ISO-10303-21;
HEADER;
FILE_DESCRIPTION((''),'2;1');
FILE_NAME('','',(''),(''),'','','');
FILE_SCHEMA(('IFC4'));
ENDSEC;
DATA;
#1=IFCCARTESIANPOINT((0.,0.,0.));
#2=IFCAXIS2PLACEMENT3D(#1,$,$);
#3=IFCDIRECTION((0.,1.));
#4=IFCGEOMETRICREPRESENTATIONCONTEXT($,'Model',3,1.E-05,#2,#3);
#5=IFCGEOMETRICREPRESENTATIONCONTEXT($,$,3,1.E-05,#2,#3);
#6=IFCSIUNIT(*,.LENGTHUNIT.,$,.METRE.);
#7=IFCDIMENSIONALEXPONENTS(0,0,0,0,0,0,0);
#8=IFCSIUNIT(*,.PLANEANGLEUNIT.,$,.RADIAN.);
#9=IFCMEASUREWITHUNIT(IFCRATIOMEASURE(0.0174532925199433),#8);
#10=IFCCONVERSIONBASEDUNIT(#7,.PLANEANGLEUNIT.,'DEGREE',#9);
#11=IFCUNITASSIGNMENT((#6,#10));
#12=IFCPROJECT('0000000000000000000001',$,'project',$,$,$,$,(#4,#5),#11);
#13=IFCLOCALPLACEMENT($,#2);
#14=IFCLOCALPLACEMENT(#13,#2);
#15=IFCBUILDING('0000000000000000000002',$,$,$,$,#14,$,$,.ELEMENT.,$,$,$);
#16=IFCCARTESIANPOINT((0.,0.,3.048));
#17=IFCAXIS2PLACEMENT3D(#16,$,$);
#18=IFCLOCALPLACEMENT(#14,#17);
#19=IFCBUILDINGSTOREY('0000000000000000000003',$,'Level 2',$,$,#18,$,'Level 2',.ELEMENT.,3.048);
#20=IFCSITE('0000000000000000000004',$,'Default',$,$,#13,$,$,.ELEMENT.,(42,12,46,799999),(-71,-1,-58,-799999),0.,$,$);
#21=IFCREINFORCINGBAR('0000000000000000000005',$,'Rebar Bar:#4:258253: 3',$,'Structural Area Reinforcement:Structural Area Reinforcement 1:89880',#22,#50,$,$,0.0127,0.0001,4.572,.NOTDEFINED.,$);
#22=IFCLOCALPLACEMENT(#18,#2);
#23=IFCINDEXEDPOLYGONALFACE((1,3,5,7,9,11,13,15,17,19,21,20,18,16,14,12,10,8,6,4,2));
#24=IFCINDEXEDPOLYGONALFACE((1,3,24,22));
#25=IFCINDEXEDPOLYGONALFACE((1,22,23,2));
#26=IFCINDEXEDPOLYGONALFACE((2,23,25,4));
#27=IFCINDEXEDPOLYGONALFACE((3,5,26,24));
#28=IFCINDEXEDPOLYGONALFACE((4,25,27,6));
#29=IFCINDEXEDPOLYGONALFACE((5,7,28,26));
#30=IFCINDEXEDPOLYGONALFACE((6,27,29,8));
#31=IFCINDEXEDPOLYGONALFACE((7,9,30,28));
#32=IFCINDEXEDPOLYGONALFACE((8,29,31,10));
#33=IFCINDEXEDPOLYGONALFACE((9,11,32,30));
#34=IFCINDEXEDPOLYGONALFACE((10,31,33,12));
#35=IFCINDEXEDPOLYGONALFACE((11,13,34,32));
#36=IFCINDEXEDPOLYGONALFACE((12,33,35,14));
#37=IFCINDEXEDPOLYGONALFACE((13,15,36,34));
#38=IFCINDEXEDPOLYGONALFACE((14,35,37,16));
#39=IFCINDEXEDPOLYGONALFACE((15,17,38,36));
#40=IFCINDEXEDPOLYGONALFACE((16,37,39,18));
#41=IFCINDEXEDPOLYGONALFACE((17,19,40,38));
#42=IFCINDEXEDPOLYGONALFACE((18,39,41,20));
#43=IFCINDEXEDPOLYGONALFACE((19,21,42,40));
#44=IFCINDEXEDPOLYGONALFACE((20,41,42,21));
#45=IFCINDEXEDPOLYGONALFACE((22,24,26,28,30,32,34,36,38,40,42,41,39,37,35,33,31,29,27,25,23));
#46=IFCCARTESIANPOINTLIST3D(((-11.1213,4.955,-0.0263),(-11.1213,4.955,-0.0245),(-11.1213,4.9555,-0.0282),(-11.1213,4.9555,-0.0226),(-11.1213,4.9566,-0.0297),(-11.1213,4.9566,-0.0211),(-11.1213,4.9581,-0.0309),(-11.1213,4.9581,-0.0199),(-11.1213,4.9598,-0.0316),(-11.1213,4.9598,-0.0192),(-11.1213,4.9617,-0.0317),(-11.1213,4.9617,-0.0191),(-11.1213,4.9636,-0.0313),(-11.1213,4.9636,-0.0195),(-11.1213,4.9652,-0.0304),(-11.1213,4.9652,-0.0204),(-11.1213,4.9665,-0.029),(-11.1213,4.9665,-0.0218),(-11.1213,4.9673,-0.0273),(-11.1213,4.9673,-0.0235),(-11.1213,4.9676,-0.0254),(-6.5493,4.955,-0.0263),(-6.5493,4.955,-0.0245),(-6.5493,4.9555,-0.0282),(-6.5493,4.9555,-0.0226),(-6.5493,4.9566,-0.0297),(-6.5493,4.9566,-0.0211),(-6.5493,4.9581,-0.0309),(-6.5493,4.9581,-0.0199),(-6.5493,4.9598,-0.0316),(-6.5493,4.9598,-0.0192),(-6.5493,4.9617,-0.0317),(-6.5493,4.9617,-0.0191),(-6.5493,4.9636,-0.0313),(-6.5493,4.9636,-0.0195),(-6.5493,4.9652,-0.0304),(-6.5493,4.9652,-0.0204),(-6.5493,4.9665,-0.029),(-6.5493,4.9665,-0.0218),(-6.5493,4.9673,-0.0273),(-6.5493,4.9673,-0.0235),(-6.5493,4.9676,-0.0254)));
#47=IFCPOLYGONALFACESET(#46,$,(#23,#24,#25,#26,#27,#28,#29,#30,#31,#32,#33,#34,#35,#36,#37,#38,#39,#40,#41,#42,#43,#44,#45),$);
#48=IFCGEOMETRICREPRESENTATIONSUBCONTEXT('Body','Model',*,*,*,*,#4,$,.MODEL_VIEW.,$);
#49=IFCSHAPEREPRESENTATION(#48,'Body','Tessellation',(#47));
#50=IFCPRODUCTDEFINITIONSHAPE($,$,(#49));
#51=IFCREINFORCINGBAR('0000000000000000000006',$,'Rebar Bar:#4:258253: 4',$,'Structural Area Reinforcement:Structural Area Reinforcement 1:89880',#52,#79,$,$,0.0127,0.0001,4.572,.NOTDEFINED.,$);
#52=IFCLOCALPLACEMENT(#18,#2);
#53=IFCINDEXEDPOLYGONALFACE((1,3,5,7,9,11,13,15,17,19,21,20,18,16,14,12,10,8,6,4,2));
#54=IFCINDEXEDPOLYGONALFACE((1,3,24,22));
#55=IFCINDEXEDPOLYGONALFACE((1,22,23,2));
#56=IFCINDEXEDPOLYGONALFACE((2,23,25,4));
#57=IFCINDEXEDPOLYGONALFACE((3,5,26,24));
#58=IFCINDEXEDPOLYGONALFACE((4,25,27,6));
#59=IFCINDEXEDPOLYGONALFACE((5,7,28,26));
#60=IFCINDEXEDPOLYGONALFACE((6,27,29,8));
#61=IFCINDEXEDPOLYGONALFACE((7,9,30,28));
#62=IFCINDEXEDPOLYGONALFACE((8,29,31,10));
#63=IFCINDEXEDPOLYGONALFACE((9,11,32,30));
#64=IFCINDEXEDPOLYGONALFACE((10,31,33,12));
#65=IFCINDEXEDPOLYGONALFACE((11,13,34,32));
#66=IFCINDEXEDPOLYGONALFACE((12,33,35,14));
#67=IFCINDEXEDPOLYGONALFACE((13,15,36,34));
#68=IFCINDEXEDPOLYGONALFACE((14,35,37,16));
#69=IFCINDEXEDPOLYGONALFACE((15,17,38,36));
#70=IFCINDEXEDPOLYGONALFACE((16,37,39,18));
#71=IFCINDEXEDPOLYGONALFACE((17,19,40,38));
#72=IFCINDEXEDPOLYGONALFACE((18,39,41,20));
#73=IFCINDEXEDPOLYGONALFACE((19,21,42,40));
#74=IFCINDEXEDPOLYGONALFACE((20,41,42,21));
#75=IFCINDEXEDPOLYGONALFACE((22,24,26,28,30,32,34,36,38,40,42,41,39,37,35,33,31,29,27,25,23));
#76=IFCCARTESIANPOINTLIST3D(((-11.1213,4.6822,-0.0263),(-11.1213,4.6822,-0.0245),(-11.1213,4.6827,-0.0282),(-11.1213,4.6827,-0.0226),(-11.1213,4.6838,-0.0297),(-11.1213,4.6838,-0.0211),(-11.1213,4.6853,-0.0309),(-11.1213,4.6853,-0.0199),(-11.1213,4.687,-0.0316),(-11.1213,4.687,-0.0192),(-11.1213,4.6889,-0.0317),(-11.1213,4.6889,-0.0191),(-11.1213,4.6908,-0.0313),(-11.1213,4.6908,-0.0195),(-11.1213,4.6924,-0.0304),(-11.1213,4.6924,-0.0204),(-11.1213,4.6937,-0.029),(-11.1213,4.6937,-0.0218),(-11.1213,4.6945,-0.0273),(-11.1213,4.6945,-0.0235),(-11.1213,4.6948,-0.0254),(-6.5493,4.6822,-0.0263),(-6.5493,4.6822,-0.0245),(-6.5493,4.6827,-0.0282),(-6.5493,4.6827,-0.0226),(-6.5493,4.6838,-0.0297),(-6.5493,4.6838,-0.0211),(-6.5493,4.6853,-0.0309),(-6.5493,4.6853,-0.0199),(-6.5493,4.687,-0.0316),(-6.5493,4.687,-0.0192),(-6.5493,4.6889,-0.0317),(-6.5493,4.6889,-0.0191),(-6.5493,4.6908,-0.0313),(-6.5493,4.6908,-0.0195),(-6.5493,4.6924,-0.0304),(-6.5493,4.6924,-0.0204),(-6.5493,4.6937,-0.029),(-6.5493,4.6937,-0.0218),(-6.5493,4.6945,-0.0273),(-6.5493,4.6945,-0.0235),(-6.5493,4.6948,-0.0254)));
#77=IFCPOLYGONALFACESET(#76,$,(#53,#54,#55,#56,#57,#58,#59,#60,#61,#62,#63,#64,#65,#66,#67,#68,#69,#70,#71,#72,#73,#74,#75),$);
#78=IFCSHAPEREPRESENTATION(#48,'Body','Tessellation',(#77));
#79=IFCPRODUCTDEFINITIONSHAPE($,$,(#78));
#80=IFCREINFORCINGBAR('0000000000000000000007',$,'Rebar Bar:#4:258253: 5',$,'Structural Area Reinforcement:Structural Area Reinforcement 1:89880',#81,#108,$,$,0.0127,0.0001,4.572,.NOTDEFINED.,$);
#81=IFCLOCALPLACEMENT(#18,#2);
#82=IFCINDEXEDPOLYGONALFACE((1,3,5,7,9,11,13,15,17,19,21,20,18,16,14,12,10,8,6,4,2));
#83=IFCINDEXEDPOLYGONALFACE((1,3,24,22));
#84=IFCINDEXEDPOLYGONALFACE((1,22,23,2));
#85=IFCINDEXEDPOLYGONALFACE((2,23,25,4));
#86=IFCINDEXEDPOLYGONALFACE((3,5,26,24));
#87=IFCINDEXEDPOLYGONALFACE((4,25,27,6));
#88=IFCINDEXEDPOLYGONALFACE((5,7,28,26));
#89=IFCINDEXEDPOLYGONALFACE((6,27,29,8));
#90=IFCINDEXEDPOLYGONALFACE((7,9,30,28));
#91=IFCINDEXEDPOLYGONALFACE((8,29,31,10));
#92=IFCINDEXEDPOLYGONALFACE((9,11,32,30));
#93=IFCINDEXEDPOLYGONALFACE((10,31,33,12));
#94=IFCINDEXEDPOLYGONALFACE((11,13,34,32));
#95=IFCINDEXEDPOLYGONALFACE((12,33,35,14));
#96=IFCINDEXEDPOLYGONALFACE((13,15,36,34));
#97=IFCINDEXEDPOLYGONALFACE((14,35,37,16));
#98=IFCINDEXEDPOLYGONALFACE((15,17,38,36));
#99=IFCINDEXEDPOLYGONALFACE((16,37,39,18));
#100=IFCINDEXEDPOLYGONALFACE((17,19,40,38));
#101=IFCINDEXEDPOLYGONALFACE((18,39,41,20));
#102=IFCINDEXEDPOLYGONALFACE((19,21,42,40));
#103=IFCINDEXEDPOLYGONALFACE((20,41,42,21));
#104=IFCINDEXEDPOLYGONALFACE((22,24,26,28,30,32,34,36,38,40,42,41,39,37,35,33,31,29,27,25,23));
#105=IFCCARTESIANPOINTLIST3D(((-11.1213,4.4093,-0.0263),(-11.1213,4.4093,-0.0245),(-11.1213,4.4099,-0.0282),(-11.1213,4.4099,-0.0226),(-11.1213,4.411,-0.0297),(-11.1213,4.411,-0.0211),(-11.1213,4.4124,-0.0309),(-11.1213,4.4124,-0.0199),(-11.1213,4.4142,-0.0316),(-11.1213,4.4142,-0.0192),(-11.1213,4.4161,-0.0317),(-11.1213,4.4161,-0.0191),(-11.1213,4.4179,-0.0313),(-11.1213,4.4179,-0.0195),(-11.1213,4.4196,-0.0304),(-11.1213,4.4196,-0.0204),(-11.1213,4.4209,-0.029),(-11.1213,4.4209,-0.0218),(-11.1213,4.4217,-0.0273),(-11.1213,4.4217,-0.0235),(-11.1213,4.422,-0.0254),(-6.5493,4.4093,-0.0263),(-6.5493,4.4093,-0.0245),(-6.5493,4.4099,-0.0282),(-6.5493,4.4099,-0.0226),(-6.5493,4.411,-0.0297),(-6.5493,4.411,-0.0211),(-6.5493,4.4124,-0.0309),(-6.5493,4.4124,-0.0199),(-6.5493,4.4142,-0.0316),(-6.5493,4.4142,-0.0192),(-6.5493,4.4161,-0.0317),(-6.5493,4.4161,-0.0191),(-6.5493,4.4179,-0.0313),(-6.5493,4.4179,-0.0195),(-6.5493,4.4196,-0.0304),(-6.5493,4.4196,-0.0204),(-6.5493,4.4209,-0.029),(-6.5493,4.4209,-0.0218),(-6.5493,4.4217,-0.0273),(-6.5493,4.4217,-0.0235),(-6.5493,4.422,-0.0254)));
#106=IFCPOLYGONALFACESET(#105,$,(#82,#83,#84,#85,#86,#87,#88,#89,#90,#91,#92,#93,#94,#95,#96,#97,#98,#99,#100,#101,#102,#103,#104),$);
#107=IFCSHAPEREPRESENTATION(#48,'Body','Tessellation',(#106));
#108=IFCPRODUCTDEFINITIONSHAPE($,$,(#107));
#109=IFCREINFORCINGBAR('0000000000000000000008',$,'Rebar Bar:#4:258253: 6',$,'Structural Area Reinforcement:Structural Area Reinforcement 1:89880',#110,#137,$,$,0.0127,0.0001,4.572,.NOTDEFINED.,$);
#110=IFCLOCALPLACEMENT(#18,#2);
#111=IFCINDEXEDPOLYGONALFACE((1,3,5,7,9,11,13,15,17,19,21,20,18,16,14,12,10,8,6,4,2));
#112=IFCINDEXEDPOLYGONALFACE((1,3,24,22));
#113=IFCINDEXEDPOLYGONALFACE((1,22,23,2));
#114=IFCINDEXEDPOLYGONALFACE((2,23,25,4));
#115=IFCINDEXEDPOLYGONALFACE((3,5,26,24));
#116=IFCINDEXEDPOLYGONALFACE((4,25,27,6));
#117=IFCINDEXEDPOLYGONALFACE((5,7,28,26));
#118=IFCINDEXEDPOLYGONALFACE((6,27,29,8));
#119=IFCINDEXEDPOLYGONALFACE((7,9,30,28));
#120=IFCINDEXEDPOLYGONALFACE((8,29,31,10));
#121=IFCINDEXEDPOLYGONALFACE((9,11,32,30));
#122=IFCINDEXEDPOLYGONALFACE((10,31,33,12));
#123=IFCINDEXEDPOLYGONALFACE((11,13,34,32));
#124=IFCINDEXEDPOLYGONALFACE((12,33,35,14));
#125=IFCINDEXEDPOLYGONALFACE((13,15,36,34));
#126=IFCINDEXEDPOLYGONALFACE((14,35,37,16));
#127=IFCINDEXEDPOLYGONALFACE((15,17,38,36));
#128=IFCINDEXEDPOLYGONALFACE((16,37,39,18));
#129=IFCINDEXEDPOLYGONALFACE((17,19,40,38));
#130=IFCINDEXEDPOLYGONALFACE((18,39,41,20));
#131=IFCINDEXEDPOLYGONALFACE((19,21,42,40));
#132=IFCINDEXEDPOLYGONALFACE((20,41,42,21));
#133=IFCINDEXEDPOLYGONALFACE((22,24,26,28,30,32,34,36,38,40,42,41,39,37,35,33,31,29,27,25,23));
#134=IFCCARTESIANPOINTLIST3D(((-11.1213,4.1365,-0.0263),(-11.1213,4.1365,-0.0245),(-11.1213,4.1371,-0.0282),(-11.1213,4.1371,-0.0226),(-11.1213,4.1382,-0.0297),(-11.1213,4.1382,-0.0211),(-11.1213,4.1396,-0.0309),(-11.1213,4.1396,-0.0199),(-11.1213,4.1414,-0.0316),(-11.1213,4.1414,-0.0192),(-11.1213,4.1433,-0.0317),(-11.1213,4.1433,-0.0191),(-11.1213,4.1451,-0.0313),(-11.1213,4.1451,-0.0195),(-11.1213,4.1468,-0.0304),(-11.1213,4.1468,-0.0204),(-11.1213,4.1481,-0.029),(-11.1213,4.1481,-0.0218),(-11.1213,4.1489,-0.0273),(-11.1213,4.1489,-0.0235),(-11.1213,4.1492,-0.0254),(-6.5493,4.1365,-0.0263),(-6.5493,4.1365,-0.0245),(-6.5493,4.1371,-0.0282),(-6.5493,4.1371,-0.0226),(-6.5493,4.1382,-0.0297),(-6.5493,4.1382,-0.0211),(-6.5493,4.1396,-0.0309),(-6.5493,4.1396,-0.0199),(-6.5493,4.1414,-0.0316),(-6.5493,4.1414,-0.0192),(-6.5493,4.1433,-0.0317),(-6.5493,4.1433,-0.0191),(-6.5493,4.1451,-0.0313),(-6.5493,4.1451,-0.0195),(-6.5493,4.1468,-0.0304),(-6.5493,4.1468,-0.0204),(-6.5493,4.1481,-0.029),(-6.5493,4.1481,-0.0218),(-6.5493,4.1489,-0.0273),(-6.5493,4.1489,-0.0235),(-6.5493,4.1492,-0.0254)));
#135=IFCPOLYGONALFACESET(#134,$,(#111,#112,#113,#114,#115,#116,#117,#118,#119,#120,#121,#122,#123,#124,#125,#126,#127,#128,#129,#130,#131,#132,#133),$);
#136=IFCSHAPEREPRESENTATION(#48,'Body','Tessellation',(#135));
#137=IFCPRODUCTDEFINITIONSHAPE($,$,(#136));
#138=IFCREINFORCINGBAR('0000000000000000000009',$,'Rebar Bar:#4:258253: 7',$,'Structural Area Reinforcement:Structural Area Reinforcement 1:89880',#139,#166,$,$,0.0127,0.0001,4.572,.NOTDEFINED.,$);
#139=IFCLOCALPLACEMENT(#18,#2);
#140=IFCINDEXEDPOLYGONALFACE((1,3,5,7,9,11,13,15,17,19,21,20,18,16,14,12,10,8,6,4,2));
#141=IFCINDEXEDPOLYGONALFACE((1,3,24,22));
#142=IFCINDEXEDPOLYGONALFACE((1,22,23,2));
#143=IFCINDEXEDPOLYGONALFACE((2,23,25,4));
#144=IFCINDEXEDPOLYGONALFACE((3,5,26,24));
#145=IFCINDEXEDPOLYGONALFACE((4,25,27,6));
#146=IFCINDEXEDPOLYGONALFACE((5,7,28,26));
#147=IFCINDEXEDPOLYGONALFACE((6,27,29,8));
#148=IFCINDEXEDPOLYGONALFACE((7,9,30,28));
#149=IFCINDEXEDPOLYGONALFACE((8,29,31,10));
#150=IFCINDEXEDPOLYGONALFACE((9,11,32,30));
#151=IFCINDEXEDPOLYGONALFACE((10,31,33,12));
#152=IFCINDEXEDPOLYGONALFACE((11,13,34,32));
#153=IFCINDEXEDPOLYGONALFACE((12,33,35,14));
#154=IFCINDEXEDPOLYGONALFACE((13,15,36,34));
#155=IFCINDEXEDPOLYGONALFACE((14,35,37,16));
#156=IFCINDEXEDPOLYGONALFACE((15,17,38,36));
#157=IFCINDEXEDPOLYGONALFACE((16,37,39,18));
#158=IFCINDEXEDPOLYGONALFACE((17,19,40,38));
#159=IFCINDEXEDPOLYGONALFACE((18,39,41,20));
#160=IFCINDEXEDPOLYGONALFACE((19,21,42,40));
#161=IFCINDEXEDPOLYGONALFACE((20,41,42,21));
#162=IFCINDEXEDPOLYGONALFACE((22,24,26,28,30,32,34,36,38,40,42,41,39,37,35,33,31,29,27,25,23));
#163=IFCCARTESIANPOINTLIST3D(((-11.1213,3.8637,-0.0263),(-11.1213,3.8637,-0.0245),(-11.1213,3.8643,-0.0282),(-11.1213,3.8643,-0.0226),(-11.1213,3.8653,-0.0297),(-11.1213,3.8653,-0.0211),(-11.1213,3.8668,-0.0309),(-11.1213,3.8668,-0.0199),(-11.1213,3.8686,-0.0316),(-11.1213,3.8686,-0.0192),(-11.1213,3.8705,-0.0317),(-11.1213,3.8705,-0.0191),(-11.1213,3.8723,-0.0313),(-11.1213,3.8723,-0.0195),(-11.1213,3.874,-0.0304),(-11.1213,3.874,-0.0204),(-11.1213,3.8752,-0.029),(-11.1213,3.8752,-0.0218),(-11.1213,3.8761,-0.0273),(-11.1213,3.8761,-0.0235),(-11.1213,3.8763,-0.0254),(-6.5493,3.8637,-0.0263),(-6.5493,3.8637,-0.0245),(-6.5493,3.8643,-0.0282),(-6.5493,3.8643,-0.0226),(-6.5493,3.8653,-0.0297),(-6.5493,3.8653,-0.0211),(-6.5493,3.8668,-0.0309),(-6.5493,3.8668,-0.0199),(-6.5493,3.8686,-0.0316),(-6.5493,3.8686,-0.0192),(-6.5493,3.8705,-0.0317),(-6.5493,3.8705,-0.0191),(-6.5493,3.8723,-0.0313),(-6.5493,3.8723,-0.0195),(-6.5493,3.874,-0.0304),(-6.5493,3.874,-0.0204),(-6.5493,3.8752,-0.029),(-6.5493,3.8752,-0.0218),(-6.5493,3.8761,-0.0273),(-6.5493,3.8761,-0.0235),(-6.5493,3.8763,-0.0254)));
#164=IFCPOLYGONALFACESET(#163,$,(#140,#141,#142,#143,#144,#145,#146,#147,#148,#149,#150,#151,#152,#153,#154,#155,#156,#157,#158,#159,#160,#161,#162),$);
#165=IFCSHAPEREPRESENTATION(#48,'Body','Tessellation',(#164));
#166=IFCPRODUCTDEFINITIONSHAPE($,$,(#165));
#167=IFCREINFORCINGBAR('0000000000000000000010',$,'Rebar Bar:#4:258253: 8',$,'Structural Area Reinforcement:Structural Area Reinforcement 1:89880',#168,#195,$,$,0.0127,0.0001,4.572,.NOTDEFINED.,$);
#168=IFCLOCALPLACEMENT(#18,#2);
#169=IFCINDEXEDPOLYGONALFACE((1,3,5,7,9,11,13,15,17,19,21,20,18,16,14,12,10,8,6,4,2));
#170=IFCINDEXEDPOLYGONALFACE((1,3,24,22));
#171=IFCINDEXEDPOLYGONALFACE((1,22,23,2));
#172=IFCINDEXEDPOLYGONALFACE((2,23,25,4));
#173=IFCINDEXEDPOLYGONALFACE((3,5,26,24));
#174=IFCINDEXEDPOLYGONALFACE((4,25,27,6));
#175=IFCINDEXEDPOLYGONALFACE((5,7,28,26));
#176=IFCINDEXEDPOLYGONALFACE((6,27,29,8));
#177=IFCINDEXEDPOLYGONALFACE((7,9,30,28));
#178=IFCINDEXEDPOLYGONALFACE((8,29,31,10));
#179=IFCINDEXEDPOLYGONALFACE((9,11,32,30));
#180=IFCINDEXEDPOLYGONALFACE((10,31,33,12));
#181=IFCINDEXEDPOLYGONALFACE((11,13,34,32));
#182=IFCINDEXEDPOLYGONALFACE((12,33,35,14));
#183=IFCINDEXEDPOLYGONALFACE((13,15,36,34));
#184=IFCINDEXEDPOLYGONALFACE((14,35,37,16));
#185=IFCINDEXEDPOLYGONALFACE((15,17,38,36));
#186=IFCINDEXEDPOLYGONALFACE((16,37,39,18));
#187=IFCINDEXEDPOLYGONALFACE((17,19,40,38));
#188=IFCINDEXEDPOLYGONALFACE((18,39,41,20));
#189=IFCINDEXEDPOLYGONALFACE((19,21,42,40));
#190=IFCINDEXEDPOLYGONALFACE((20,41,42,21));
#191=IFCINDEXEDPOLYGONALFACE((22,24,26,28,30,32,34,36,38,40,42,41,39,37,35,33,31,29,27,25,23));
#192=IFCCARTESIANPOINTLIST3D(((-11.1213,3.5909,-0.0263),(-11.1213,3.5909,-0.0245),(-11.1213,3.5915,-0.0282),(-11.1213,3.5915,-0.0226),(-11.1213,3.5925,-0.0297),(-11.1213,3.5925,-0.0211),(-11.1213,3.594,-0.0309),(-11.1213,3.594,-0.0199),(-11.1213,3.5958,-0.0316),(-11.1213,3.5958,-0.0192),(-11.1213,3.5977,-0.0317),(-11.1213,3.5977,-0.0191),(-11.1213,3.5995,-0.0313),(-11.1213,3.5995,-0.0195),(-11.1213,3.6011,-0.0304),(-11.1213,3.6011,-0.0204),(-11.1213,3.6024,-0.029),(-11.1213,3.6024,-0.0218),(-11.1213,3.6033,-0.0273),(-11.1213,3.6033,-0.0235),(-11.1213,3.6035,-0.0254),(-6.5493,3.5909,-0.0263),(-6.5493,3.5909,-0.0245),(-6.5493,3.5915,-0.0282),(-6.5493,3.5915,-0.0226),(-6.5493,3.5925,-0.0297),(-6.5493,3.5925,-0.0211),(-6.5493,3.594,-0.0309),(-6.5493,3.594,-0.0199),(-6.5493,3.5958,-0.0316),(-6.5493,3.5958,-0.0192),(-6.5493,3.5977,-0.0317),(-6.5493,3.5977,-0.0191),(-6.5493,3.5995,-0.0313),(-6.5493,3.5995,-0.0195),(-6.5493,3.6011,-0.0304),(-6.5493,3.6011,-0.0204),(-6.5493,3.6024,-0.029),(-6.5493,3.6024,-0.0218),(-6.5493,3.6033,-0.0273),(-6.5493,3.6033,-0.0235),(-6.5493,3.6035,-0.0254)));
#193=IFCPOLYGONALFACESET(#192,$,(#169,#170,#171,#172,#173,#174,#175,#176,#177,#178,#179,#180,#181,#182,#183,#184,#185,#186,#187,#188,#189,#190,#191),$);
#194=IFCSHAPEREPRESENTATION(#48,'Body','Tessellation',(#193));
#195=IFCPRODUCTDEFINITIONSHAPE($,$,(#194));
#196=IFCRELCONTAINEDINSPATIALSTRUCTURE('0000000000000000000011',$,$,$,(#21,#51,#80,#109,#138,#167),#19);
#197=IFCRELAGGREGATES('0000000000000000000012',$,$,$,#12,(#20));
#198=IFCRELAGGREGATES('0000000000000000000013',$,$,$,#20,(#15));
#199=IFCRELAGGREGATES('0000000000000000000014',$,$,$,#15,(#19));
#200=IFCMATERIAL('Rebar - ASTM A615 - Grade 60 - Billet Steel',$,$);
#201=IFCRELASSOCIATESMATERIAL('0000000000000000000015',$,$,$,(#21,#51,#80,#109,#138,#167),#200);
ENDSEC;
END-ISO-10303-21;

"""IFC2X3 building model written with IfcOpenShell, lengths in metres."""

from ifc_helpers import new_model, entity, si_unit, converted_unit, direction, frame, origin, place, context, subcontext, project, spatial, material, element, save


model = new_model("IFC2X3")

# Units and contexts
model_context = context("Model", 3, precision=1e-05, world=origin(), true_north=direction((0.0, 1.0)))
context_of_model = context(None, 3, precision=1e-05, world=origin(), true_north=direction((0.0, 1.0)))
body_context = subcontext(model_context, "Body", "Model", "MODEL_VIEW")
ifc_project = project(units=[si_unit("LENGTHUNIT", "METRE"), converted_unit("PLANEANGLEUNIT", "DEGREE", entity("IfcRatioMeasure", 0.0174532925199433), si_unit("PLANEANGLEUNIT", "RADIAN"), dimensions=[0, 0, 0, 0, 0, 0, 0])], contexts=[model_context, context_of_model])

# Site, building, storey
site_placement = place(None, origin())
site = spatial("IfcSite", under=ifc_project, at=site_placement, Name="Default", CompositionType="ELEMENT", RefLatitude=(42, 12, 46, 799999), RefLongitude=(-71, -1, -58, -799999), RefElevation=0.0)
building_placement = place(site_placement, origin())
building = spatial("IfcBuilding", under=site, at=building_placement, CompositionType="ELEMENT")
storey_placement = place(building_placement, frame((0.0, 0.0, 3.048)))
storey = spatial("IfcBuildingStorey", under=building, at=storey_placement, Name="Level 2", LongName="Level 2", CompositionType="ELEMENT", Elevation=3.048)

# Reinforcing bars
ifc_material_1 = material(Name="Rebar - ASTM A615 - Grade 60 - Billet Steel")
reinforcing_bar_1_placement = place(storey_placement, origin())
element("IfcReinforcingBar", 1, at=reinforcing_bar_1_placement, inside=storey, material=ifc_material_1, Name="Rebar Bar:#4:258253: 3", ObjectType="Structural Area Reinforcement:Structural Area Reinforcement 1:89880", BarLength=4.572, BarRole="NOTDEFINED", CrossSectionArea=0.0001, NominalDiameter=0.0127, context=body_context, shape_type="AdvancedSweptSolid", body=[
    entity("IfcSweptDiskSolid", entity("IfcCompositeCurve", [entity("IfcCompositeCurveSegment", "CONTINUOUS", True, entity("IfcPolyline", [entity("IfcCartesianPoint", [-11.1213, 4.9612, -0.0254]), entity("IfcCartesianPoint", [-6.5493, 4.9612, -0.0254])]))], False), 0.0063, None, 0.0, 1.0),
])
reinforcing_bar_2_placement = place(storey_placement, origin())
element("IfcReinforcingBar", 2, at=reinforcing_bar_2_placement, inside=storey, material=ifc_material_1, Name="Rebar Bar:#4:258253: 4", ObjectType="Structural Area Reinforcement:Structural Area Reinforcement 1:89880", BarLength=4.572, BarRole="NOTDEFINED", CrossSectionArea=0.0001, NominalDiameter=0.0127, context=body_context, shape_type="AdvancedSweptSolid", body=[
    entity("IfcSweptDiskSolid", entity("IfcCompositeCurve", [entity("IfcCompositeCurveSegment", "CONTINUOUS", True, entity("IfcPolyline", [entity("IfcCartesianPoint", [-11.1213, 4.6884, -0.0254]), entity("IfcCartesianPoint", [-6.5493, 4.6884, -0.0254])]))], False), 0.0063, None, 0.0, 1.0),
])
reinforcing_bar_3_placement = place(storey_placement, origin())
element("IfcReinforcingBar", 3, at=reinforcing_bar_3_placement, inside=storey, material=ifc_material_1, Name="Rebar Bar:#4:258253: 5", ObjectType="Structural Area Reinforcement:Structural Area Reinforcement 1:89880", BarLength=4.572, BarRole="NOTDEFINED", CrossSectionArea=0.0001, NominalDiameter=0.0127, context=body_context, shape_type="AdvancedSweptSolid", body=[
    entity("IfcSweptDiskSolid", entity("IfcCompositeCurve", [entity("IfcCompositeCurveSegment", "CONTINUOUS", True, entity("IfcPolyline", [entity("IfcCartesianPoint", [-11.1213, 4.4156, -0.0254]), entity("IfcCartesianPoint", [-6.5493, 4.4156, -0.0254])]))], False), 0.0063, None, 0.0, 1.0),
])
reinforcing_bar_4_placement = place(storey_placement, origin())
element("IfcReinforcingBar", 4, at=reinforcing_bar_4_placement, inside=storey, material=ifc_material_1, Name="Rebar Bar:#4:258253: 6", ObjectType="Structural Area Reinforcement:Structural Area Reinforcement 1:89880", BarLength=4.572, BarRole="NOTDEFINED", CrossSectionArea=0.0001, NominalDiameter=0.0127, context=body_context, shape_type="AdvancedSweptSolid", body=[
    entity("IfcSweptDiskSolid", entity("IfcCompositeCurve", [entity("IfcCompositeCurveSegment", "CONTINUOUS", True, entity("IfcPolyline", [entity("IfcCartesianPoint", [-11.1213, 4.1428, -0.0254]), entity("IfcCartesianPoint", [-6.5493, 4.1428, -0.0254])]))], False), 0.0063, None, 0.0, 1.0),
])
reinforcing_bar_5_placement = place(storey_placement, origin())
element("IfcReinforcingBar", 5, at=reinforcing_bar_5_placement, inside=storey, material=ifc_material_1, Name="Rebar Bar:#4:258253: 7", ObjectType="Structural Area Reinforcement:Structural Area Reinforcement 1:89880", BarLength=4.572, BarRole="NOTDEFINED", CrossSectionArea=0.0001, NominalDiameter=0.0127, context=body_context, shape_type="AdvancedSweptSolid", body=[
    entity("IfcSweptDiskSolid", entity("IfcCompositeCurve", [entity("IfcCompositeCurveSegment", "CONTINUOUS", True, entity("IfcPolyline", [entity("IfcCartesianPoint", [-11.1213, 3.87, -0.0254]), entity("IfcCartesianPoint", [-6.5493, 3.87, -0.0254])]))], False), 0.0063, None, 0.0, 1.0),
])
reinforcing_bar_6_placement = place(storey_placement, origin())
element("IfcReinforcingBar", 6, at=reinforcing_bar_6_placement, inside=storey, material=ifc_material_1, Name="Rebar Bar:#4:258253: 8", ObjectType="Structural Area Reinforcement:Structural Area Reinforcement 1:89880", BarLength=4.572, BarRole="NOTDEFINED", CrossSectionArea=0.0001, NominalDiameter=0.0127, context=body_context, shape_type="AdvancedSweptSolid", body=[
    entity("IfcSweptDiskSolid", entity("IfcCompositeCurve", [entity("IfcCompositeCurveSegment", "CONTINUOUS", True, entity("IfcPolyline", [entity("IfcCartesianPoint", [-11.1213, 3.5972, -0.0254]), entity("IfcCartesianPoint", [-6.5493, 3.5972, -0.0254])]))], False), 0.0063, None, 0.0, 1.0),
])

save(model, "model.ifc")
